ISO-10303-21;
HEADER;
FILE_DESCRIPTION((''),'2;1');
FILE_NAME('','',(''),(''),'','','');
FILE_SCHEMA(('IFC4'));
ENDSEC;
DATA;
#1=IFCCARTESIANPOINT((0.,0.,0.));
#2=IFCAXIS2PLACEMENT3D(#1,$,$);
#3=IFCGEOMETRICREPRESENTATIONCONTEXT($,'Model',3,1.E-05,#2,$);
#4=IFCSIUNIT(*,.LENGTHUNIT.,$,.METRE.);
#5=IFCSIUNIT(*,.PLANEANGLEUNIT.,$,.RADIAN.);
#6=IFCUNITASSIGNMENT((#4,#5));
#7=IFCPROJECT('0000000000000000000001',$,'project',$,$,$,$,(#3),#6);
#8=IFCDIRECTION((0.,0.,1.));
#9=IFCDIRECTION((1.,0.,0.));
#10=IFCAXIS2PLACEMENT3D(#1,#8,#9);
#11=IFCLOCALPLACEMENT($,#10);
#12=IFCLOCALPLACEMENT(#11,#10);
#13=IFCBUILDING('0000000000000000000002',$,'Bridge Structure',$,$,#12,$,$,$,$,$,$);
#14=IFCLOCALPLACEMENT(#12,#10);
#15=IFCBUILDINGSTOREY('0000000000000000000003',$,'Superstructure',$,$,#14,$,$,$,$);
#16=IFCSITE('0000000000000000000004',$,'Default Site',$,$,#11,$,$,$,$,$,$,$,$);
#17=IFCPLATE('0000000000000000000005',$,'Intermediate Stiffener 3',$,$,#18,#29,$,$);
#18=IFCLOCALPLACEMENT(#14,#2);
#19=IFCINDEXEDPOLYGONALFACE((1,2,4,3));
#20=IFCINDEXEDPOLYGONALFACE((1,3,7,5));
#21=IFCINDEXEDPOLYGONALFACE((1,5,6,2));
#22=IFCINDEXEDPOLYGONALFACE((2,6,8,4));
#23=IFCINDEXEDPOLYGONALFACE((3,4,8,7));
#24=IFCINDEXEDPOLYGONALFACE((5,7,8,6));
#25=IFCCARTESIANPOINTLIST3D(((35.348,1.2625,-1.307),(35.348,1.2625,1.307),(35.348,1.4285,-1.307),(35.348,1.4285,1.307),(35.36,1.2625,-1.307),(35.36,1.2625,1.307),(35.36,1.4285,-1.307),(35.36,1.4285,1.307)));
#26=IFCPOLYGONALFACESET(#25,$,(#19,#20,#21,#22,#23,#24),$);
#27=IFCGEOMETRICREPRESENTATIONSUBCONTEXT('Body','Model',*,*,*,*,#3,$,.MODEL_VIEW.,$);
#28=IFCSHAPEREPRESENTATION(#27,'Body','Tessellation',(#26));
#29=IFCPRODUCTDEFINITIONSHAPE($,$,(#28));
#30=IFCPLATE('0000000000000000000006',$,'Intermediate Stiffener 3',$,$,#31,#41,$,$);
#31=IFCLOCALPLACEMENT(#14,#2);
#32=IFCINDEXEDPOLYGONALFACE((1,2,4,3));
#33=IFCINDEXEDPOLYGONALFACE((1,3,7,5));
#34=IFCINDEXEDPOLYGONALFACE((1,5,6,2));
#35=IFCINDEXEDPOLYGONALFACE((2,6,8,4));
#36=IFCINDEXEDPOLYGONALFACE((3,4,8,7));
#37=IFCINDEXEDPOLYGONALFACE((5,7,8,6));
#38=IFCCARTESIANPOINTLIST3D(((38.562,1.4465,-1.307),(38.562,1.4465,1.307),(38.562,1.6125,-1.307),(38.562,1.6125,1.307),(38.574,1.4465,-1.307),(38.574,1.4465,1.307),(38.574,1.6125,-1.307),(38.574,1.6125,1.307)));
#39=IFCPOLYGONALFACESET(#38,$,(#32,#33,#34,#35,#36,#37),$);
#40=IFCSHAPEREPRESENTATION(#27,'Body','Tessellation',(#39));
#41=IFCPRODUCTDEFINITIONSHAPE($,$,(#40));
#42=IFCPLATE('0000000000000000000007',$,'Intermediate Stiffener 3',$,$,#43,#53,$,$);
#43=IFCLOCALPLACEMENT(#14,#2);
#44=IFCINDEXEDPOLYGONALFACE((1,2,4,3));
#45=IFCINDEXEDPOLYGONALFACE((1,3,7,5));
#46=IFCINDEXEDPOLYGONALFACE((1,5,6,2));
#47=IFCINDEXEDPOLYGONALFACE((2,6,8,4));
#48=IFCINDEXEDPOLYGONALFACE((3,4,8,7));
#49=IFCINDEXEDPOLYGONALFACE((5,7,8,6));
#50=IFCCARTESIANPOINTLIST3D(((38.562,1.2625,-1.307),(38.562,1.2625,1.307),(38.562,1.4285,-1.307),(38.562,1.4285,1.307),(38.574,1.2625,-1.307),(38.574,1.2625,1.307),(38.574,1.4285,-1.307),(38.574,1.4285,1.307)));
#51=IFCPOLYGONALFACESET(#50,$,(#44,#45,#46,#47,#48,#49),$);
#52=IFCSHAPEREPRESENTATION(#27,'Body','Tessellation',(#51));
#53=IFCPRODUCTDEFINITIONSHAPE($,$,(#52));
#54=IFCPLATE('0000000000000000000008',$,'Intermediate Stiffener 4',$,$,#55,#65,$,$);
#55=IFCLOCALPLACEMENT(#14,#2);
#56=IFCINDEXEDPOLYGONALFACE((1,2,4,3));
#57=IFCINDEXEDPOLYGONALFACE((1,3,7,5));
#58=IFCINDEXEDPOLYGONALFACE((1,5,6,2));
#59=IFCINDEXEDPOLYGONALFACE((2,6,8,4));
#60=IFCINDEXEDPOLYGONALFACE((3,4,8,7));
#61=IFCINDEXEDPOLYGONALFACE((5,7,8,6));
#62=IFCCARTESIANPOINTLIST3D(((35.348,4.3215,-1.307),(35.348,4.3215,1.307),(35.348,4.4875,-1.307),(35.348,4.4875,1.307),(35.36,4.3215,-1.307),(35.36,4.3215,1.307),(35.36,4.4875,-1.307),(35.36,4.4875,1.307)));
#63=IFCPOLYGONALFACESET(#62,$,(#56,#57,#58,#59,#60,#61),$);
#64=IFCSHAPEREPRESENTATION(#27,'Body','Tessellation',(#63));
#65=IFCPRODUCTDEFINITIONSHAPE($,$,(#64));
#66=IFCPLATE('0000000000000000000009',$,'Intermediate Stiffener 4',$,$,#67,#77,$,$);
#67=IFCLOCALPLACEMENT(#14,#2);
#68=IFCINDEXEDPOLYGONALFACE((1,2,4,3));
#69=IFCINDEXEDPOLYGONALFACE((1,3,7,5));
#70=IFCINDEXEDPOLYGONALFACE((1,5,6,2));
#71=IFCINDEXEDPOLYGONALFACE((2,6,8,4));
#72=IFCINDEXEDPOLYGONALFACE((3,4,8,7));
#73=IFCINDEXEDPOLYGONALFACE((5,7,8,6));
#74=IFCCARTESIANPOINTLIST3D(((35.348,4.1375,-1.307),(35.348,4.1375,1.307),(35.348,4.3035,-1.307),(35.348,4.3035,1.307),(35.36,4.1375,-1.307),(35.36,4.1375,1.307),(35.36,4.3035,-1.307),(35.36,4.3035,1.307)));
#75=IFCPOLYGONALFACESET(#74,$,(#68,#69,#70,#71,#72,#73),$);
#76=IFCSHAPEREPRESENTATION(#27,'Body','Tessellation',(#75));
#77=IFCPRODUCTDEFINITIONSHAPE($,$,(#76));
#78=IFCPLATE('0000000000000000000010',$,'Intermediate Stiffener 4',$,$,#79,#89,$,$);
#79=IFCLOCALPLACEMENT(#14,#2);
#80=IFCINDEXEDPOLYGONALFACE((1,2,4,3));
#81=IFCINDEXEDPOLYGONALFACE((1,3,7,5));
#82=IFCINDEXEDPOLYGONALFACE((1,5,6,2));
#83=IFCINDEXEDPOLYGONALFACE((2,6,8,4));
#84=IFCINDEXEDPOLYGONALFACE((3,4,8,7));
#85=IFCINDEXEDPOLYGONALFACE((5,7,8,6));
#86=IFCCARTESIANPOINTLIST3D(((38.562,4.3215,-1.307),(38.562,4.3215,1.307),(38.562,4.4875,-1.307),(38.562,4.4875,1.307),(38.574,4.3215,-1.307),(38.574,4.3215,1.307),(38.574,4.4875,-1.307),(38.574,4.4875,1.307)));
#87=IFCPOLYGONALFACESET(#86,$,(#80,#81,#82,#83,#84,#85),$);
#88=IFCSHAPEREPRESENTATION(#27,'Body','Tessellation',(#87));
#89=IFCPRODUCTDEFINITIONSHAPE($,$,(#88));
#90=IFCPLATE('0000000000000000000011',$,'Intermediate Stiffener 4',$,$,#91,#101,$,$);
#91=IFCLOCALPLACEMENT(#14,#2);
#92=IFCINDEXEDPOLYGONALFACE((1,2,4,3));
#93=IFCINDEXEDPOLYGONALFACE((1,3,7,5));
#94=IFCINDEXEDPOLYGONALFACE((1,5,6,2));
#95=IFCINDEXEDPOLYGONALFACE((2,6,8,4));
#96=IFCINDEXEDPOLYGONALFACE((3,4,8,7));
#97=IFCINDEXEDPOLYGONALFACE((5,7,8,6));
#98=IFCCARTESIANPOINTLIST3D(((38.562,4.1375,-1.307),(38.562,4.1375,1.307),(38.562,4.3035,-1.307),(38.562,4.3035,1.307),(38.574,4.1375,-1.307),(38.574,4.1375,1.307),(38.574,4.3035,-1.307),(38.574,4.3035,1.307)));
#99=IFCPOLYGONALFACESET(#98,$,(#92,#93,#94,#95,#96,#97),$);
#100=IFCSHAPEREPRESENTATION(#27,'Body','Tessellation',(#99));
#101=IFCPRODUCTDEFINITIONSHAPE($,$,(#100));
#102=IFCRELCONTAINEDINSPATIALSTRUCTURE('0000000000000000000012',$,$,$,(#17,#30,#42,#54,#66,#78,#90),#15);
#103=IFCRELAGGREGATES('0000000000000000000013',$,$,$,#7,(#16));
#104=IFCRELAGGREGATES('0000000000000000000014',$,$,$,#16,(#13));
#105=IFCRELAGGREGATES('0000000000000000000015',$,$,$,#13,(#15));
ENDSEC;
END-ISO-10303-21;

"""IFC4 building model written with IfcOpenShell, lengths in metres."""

from ifc_helpers import new_model, si_unit, frame, origin, origin_with_axes, origin_2d_with_axis, place, context, subcontext, project, spatial, rectangle, extrude, element, save


model = new_model("IFC4")

# Units and contexts
model_context = context("Model", 3, precision=1e-05, world=origin())
body_context = subcontext(model_context, "Body", "Model", "MODEL_VIEW")
ifc_project = project(units=[si_unit("LENGTHUNIT", "METRE"), si_unit("PLANEANGLEUNIT", "RADIAN")], contexts=[model_context])

# Site, building, storey
site_placement = place(None, origin_with_axes())
site = spatial("IfcSite", under=ifc_project, at=site_placement, Name="Default Site")
building_placement = place(site_placement, origin_with_axes())
building = spatial("IfcBuilding", under=site, at=building_placement, Name="Bridge Structure")
storey_placement = place(building_placement, origin_with_axes())
storey = spatial("IfcBuildingStorey", under=building, at=storey_placement, Name="Superstructure")

# Plates
for number, where, z_axis, x_axis, name in (
    (1, (35.354, 1.3455, -1.307), (0.0, 0.0, 1.0), (1.0, 0.0, 0.0), "Intermediate Stiffener 3"),
    (2, (38.568, 1.5295, -1.307), (0.0, 0.0, 1.0), (1.0, 0.0, 0.0), "Intermediate Stiffener 3"),
    (3, (38.568, 1.3455, -1.307), (0.0, 0.0, 1.0), (1.0, 0.0, 0.0), "Intermediate Stiffener 3"),
    (4, (35.354, 4.4045, -1.307), (0.0, 0.0, 1.0), (1.0, 0.0, 0.0), "Intermediate Stiffener 4"),
    (5, (35.354, 4.2205, -1.307), (0.0, 0.0, 1.0), (1.0, 0.0, 0.0), "Intermediate Stiffener 4"),
    (6, (38.568, 4.4045, -1.307), (0.0, 0.0, 1.0), (1.0, 0.0, 0.0), "Intermediate Stiffener 4"),
    (7, (38.568, 4.2205, -1.307), (0.0, 0.0, 1.0), (1.0, 0.0, 0.0), "Intermediate Stiffener 4"),
):
    element("IfcPlate", number, at=place(storey_placement, frame(where, z_axis=z_axis, x_axis=x_axis)), inside=storey, Name=name, context=body_context, shape_type="SweptSolid", body=[
        extrude(rectangle(XDim=0.012, YDim=0.166, at=origin_2d_with_axis()), origin_with_axes(), (0.0, 0.0, 1.0), 2.614),
    ])

save(model, "model.ifc")
